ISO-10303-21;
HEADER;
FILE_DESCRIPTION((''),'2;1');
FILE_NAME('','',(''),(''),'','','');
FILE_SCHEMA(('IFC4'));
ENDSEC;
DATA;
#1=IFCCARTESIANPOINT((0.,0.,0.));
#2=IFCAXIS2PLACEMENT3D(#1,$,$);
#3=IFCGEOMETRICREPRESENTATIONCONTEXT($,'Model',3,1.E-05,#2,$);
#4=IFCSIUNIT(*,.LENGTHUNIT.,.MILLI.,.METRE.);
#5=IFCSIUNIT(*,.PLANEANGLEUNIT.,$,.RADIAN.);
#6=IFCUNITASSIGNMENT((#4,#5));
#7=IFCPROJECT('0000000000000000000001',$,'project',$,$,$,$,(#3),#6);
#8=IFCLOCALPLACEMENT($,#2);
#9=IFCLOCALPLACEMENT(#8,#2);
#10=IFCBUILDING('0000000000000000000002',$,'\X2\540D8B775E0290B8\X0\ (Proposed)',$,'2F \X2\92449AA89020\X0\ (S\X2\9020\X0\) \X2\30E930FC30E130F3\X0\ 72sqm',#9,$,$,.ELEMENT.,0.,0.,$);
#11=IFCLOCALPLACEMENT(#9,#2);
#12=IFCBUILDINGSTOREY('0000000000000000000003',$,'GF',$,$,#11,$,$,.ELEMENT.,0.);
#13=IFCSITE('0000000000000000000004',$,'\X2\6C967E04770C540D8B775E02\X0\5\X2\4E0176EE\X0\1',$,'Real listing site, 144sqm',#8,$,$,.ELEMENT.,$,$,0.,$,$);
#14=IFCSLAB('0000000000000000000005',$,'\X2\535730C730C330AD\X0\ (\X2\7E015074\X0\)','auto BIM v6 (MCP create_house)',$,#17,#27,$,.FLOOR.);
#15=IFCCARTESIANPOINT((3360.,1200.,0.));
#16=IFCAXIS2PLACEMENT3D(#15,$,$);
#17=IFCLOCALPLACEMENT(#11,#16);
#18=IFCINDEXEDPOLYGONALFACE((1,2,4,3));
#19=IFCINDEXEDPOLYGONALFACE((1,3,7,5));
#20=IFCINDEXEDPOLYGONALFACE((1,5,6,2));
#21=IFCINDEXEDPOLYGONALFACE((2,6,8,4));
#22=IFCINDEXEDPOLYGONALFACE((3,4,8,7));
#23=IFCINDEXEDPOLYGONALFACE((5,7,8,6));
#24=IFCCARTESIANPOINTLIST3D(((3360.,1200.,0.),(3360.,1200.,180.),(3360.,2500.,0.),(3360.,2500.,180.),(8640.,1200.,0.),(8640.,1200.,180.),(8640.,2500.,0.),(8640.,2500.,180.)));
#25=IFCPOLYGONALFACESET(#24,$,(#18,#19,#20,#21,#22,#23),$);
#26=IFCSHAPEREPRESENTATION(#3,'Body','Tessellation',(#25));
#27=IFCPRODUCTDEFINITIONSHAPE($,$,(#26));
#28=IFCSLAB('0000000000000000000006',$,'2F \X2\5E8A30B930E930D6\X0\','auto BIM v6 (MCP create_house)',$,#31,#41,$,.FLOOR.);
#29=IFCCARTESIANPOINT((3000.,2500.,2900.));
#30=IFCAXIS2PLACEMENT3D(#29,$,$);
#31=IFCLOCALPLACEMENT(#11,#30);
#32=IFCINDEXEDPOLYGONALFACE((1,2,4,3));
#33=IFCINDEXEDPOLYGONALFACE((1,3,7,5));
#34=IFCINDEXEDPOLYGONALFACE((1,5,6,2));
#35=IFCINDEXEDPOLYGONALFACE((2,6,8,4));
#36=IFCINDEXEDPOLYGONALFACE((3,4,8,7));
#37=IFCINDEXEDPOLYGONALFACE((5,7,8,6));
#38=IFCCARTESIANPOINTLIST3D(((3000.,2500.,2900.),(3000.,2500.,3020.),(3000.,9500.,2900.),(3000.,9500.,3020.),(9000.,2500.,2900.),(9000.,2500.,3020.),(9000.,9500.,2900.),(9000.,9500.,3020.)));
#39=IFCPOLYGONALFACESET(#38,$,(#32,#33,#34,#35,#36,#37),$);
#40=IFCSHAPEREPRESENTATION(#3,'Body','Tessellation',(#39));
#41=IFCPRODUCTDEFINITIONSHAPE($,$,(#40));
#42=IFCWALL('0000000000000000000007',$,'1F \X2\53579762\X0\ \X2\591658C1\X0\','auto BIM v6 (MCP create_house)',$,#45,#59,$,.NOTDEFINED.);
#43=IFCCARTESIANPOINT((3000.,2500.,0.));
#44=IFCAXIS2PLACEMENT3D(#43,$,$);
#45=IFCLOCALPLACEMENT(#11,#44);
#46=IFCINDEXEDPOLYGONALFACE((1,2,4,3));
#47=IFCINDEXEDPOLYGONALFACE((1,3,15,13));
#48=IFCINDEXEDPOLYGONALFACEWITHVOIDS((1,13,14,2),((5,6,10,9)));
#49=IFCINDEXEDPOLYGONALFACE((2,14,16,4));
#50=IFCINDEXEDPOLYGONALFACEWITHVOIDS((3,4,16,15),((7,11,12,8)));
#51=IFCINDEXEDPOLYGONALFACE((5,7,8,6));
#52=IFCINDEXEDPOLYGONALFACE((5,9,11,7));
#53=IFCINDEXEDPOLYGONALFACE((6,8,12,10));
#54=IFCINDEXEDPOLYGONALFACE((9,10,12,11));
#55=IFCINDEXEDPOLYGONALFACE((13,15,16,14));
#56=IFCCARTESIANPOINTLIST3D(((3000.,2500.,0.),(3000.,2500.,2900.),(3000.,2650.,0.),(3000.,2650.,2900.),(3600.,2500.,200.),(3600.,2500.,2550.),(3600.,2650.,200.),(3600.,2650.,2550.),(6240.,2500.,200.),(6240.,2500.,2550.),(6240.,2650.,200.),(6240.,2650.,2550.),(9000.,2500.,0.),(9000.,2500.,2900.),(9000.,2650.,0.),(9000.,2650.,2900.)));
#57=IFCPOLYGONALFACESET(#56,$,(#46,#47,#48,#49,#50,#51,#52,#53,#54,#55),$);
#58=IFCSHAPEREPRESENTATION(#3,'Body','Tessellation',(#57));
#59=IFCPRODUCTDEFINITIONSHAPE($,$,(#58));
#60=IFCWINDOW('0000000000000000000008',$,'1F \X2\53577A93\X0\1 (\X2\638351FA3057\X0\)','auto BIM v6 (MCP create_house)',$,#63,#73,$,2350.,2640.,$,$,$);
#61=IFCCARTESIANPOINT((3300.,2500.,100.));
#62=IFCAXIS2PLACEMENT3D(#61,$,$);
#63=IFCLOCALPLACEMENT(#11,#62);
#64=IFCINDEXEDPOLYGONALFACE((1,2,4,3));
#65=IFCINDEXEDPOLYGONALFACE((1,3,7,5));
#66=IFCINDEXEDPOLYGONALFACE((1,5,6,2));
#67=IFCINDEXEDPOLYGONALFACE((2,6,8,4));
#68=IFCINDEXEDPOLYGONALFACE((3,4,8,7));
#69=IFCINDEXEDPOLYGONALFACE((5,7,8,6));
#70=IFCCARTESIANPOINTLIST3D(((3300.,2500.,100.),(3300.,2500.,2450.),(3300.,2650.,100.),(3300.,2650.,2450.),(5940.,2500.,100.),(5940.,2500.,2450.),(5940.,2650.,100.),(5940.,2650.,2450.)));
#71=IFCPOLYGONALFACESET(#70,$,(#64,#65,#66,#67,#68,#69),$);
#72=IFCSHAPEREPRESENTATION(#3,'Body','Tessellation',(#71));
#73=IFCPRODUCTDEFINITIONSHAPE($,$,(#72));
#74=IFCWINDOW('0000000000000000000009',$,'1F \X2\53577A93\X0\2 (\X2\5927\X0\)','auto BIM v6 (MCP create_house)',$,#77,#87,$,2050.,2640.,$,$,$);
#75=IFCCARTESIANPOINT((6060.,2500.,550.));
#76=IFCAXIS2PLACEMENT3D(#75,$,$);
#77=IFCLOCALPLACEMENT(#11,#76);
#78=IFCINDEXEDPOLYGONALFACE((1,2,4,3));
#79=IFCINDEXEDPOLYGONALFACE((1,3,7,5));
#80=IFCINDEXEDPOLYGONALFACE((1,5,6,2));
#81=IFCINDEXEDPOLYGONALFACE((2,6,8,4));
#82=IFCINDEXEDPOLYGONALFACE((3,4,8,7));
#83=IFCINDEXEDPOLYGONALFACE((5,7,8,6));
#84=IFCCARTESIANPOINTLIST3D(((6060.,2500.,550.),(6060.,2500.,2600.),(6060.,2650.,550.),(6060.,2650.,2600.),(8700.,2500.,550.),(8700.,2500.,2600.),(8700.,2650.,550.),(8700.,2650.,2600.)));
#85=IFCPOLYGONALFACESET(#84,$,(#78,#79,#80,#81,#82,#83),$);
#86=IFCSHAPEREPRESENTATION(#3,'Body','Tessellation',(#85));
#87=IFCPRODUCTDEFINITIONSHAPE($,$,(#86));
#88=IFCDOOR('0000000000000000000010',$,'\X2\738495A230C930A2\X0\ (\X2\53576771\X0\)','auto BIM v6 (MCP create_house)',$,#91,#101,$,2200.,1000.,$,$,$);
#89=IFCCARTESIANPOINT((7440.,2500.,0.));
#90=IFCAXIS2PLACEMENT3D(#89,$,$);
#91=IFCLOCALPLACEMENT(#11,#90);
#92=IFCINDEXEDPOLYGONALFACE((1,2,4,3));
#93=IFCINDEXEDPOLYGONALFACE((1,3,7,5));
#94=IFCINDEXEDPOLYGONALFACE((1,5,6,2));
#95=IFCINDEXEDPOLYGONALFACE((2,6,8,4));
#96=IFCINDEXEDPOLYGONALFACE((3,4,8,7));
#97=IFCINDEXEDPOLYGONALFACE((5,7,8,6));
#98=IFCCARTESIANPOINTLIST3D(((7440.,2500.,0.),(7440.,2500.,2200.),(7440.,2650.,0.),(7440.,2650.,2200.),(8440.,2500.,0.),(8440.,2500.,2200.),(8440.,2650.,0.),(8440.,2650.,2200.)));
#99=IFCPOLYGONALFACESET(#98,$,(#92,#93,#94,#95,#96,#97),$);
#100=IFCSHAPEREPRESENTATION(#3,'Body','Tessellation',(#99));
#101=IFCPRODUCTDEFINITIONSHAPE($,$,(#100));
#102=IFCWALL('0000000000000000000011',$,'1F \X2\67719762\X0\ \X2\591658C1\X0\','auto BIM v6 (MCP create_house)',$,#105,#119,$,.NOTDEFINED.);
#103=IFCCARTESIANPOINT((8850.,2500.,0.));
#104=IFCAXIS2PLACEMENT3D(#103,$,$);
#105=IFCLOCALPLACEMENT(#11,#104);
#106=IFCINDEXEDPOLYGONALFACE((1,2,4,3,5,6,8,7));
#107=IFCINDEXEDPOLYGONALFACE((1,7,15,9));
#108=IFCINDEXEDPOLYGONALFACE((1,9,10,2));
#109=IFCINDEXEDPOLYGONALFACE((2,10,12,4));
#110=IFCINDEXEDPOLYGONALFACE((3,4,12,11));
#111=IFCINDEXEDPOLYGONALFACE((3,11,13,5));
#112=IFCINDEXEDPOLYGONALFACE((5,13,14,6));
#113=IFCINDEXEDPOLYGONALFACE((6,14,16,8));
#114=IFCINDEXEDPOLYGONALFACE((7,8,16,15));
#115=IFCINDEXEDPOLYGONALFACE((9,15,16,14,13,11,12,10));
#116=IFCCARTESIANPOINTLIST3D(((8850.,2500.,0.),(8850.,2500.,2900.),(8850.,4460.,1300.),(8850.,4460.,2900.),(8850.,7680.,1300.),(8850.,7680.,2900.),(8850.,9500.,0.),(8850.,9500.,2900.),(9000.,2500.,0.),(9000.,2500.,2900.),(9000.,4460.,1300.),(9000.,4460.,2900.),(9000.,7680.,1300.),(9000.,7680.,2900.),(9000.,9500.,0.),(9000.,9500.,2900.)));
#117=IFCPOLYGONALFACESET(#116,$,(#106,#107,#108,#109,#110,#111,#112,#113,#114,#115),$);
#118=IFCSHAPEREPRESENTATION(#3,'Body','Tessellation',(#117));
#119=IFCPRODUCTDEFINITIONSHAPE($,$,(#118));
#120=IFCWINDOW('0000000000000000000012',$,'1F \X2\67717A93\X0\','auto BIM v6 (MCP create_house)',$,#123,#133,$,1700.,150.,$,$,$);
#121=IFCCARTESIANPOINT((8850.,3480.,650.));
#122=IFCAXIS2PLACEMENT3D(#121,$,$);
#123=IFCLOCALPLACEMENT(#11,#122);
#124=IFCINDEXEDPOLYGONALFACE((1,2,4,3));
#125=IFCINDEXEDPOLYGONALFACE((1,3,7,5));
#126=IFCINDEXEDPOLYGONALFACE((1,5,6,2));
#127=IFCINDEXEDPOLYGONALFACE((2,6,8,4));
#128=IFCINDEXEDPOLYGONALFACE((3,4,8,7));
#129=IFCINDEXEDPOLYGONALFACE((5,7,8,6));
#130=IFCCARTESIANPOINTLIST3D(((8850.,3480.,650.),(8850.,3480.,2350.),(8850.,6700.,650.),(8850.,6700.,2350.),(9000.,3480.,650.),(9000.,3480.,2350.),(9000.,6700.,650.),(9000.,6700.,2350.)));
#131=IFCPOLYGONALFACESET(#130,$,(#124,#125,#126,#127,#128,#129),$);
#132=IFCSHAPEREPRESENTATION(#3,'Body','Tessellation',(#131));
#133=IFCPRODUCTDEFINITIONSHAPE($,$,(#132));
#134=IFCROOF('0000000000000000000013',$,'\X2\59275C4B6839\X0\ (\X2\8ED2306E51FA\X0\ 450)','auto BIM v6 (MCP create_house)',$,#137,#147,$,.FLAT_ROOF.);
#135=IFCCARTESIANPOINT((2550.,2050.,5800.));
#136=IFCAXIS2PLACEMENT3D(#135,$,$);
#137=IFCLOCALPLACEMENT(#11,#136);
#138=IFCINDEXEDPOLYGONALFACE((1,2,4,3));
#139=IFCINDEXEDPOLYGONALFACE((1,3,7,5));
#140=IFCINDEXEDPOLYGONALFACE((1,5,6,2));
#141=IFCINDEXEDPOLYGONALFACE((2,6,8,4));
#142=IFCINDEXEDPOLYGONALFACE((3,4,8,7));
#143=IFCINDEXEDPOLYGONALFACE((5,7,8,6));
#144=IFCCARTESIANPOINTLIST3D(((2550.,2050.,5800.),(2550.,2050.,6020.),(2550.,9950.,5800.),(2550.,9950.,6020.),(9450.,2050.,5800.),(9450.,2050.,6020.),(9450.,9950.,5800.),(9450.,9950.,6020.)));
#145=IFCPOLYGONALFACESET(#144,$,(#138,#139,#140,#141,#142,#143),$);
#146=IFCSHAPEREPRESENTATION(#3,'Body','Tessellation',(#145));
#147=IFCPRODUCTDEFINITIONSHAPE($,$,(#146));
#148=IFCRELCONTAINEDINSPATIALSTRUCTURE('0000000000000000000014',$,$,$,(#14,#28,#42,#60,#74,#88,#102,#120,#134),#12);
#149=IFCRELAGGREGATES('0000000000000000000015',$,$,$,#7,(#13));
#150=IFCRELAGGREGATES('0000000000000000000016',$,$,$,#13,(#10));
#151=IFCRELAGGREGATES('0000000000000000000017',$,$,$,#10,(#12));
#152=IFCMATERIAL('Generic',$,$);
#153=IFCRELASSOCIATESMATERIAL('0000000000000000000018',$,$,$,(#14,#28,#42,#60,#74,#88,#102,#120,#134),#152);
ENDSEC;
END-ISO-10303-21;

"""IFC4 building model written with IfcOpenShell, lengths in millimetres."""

from ifc_helpers import new_model, si_unit, frame, frame_2d, origin, place, context, project, spatial, rectangle, extrude, material, element, fill, save


model = new_model("IFC4")

# Units and contexts
model_context = context("Model", 3, precision=1e-05, world=origin())
ifc_project = project(units=[si_unit("LENGTHUNIT", "METRE", prefix="MILLI"), si_unit("PLANEANGLEUNIT", "RADIAN")], contexts=[model_context])

# Site, building, storey
site_placement = place(None, origin())
site = spatial("IfcSite", under=ifc_project, at=site_placement, Name="沖縄県名護市5丁目1", ObjectType="Real listing site, 144sqm", CompositionType="ELEMENT", RefElevation=0.0)
building_placement = place(site_placement, origin())
building = spatial("IfcBuilding", under=site, at=building_placement, Name="名護市邸 (Proposed)", ObjectType="2F 鉄骨造 (S造) ラーメン 72sqm", CompositionType="ELEMENT", ElevationOfRefHeight=0.0, ElevationOfTerrain=0.0)
storey_placement = place(building_placement, origin())
storey = spatial("IfcBuildingStorey", under=building, at=storey_placement, Name="GF", CompositionType="ELEMENT", Elevation=0.0)

# Slabs
ifc_material = material(Name="Generic")
slab_1_placement = place(storey_placement, frame((3360.0, 1200.0, 0.0)))
element("IfcSlab", 1, at=slab_1_placement, inside=storey, material=ifc_material, Name="南デッキ (縁側)", Description="auto BIM v6 (MCP create_house)", PredefinedType="FLOOR", context=model_context, shape_type="SweptSolid", body=[
    extrude(rectangle(XDim=5280.0, YDim=1300.0, at=frame_2d((2640.0, 650.0))), frame((3360.0, 1200.0, 0.0)), (0.0, 0.0, 1.0), 180.0),
])
slab_2_placement = place(storey_placement, frame((3000.0, 2500.0, 2900.0)))
element("IfcSlab", 2, at=slab_2_placement, inside=storey, material=ifc_material, Name="2F 床スラブ", Description="auto BIM v6 (MCP create_house)", PredefinedType="FLOOR", context=model_context, shape_type="SweptSolid", body=[
    extrude(rectangle(XDim=6000.0, YDim=7000.0, at=frame_2d((3000.0, 3500.0))), frame((3000.0, 2500.0, 2900.0)), (0.0, 0.0, 1.0), 120.0),
])

# Wall, openings, windows, door
wall_1_placement = place(storey_placement, frame((3000.0, 2500.0, 0.0)))
wall_1 = element("IfcWall", 3, at=wall_1_placement, inside=storey, material=ifc_material, Name="1F 南面 外壁", Description="auto BIM v6 (MCP create_house)", PredefinedType="NOTDEFINED", context=model_context, shape_type="SweptSolid", body=[
    extrude(rectangle(XDim=6000.0, YDim=150.0, at=frame_2d((3000.0, 75.0))), frame((3000.0, 2500.0, 0.0)), (0.0, 0.0, 1.0), 2900.0),
])
opening_1_placement = place(storey_placement, frame((3300.0, 2500.0, 100.0)))
opening_1 = element("IfcOpeningElement", 4, at=opening_1_placement, cuts=wall_1, PredefinedType="NOTDEFINED", context=model_context, shape_type="SweptSolid", body=[
    extrude(rectangle(XDim=2640.0, YDim=150.0, at=frame_2d((1320.0, 75.0))), frame((3300.0, 2500.0, 100.0)), (0.0, 0.0, 1.0), 2350.0),
])
opening_2_placement = place(storey_placement, frame((6060.0, 2500.0, 550.0)))
opening_2 = element("IfcOpeningElement", 5, at=opening_2_placement, cuts=wall_1, PredefinedType="NOTDEFINED", context=model_context, shape_type="SweptSolid", body=[
    extrude(rectangle(XDim=2640.0, YDim=150.0, at=frame_2d((1320.0, 75.0))), frame((6060.0, 2500.0, 550.0)), (0.0, 0.0, 1.0), 2050.0),
])
opening_3_placement = place(storey_placement, frame((7440.0, 2500.0, 0.0)))
opening_3 = element("IfcOpeningElement", 6, at=opening_3_placement, cuts=wall_1, PredefinedType="NOTDEFINED", context=model_context, shape_type="SweptSolid", body=[
    extrude(rectangle(XDim=1000.0, YDim=150.0, at=frame_2d((500.0, 75.0))), frame((7440.0, 2500.0, 0.0)), (0.0, 0.0, 1.0), 2200.0),
])
window_1_placement = place(storey_placement, frame((3300.0, 2500.0, 100.0)))
window_1 = element("IfcWindow", 7, at=window_1_placement, inside=storey, material=ifc_material, Name="1F 南窓1 (掃出し)", Description="auto BIM v6 (MCP create_house)", OverallHeight=2350.0, OverallWidth=2640.0, context=model_context, shape_type="SweptSolid", body=[
    extrude(rectangle(XDim=2640.0, YDim=150.0, at=frame_2d((1320.0, 75.0))), frame((3300.0, 2500.0, 100.0)), (0.0, 0.0, 1.0), 2350.0),
])
fill(opening_1, window_1)
window_2_placement = place(storey_placement, frame((6060.0, 2500.0, 550.0)))
window_2 = element("IfcWindow", 8, at=window_2_placement, inside=storey, material=ifc_material, Name="1F 南窓2 (大)", Description="auto BIM v6 (MCP create_house)", OverallHeight=2050.0, OverallWidth=2640.0, context=model_context, shape_type="SweptSolid", body=[
    extrude(rectangle(XDim=2640.0, YDim=150.0, at=frame_2d((1320.0, 75.0))), frame((6060.0, 2500.0, 550.0)), (0.0, 0.0, 1.0), 2050.0),
])
fill(opening_2, window_2)
door_placement = place(storey_placement, frame((7440.0, 2500.0, 0.0)))
door = element("IfcDoor", 9, at=door_placement, inside=storey, material=ifc_material, Name="玄関ドア (南東)", Description="auto BIM v6 (MCP create_house)", OverallHeight=2200.0, OverallWidth=1000.0, context=model_context, shape_type="SweptSolid", body=[
    extrude(rectangle(XDim=1000.0, YDim=150.0, at=frame_2d((500.0, 75.0))), frame((7440.0, 2500.0, 0.0)), (0.0, 0.0, 1.0), 2200.0),
])
fill(opening_3, door)

# Wall, opening, window
wall_2_placement = place(storey_placement, frame((8850.0, 2500.0, 0.0)))
wall_2 = element("IfcWall", 10, at=wall_2_placement, inside=storey, material=ifc_material, Name="1F 東面 外壁", Description="auto BIM v6 (MCP create_house)", PredefinedType="NOTDEFINED", context=model_context, shape_type="SweptSolid", body=[
    extrude(rectangle(XDim=150.0, YDim=7000.0, at=frame_2d((75.0, 3500.0))), frame((8850.0, 2500.0, 0.0)), (0.0, 0.0, 1.0), 2900.0),
])
opening_4_placement = place(storey_placement, frame((8850.0, 3480.0, 650.0)))
opening_4 = element("IfcOpeningElement", 11, at=opening_4_placement, cuts=wall_2, PredefinedType="NOTDEFINED", context=model_context, shape_type="SweptSolid", body=[
    extrude(rectangle(XDim=150.0, YDim=3220.0, at=frame_2d((75.0, 1610.0))), frame((8850.0, 3480.0, 650.0)), (0.0, 0.0, 1.0), 1700.0),
])
window_3_placement = place(storey_placement, frame((8850.0, 3480.0, 650.0)))
window_3 = element("IfcWindow", 12, at=window_3_placement, inside=storey, material=ifc_material, Name="1F 東窓", Description="auto BIM v6 (MCP create_house)", OverallHeight=1700.0, OverallWidth=150.0, context=model_context, shape_type="SweptSolid", body=[
    extrude(rectangle(XDim=150.0, YDim=3220.0, at=frame_2d((75.0, 1610.0))), frame((8850.0, 3480.0, 650.0)), (0.0, 0.0, 1.0), 1700.0),
])
fill(opening_4, window_3)

# Roof
roof_placement = place(storey_placement, frame((2550.0, 2050.0, 5800.0)))
element("IfcRoof", 13, at=roof_placement, inside=storey, material=ifc_material, Name="大屋根 (軒の出 450)", Description="auto BIM v6 (MCP create_house)", PredefinedType="FLAT_ROOF", context=model_context, shape_type="SweptSolid", body=[
    extrude(rectangle(XDim=6900.0, YDim=7900.0, at=frame_2d((3450.0, 3950.0))), frame((2550.0, 2050.0, 5800.0)), (0.0, 0.0, 1.0), 220.0),
])

save(model, "model.ifc")
